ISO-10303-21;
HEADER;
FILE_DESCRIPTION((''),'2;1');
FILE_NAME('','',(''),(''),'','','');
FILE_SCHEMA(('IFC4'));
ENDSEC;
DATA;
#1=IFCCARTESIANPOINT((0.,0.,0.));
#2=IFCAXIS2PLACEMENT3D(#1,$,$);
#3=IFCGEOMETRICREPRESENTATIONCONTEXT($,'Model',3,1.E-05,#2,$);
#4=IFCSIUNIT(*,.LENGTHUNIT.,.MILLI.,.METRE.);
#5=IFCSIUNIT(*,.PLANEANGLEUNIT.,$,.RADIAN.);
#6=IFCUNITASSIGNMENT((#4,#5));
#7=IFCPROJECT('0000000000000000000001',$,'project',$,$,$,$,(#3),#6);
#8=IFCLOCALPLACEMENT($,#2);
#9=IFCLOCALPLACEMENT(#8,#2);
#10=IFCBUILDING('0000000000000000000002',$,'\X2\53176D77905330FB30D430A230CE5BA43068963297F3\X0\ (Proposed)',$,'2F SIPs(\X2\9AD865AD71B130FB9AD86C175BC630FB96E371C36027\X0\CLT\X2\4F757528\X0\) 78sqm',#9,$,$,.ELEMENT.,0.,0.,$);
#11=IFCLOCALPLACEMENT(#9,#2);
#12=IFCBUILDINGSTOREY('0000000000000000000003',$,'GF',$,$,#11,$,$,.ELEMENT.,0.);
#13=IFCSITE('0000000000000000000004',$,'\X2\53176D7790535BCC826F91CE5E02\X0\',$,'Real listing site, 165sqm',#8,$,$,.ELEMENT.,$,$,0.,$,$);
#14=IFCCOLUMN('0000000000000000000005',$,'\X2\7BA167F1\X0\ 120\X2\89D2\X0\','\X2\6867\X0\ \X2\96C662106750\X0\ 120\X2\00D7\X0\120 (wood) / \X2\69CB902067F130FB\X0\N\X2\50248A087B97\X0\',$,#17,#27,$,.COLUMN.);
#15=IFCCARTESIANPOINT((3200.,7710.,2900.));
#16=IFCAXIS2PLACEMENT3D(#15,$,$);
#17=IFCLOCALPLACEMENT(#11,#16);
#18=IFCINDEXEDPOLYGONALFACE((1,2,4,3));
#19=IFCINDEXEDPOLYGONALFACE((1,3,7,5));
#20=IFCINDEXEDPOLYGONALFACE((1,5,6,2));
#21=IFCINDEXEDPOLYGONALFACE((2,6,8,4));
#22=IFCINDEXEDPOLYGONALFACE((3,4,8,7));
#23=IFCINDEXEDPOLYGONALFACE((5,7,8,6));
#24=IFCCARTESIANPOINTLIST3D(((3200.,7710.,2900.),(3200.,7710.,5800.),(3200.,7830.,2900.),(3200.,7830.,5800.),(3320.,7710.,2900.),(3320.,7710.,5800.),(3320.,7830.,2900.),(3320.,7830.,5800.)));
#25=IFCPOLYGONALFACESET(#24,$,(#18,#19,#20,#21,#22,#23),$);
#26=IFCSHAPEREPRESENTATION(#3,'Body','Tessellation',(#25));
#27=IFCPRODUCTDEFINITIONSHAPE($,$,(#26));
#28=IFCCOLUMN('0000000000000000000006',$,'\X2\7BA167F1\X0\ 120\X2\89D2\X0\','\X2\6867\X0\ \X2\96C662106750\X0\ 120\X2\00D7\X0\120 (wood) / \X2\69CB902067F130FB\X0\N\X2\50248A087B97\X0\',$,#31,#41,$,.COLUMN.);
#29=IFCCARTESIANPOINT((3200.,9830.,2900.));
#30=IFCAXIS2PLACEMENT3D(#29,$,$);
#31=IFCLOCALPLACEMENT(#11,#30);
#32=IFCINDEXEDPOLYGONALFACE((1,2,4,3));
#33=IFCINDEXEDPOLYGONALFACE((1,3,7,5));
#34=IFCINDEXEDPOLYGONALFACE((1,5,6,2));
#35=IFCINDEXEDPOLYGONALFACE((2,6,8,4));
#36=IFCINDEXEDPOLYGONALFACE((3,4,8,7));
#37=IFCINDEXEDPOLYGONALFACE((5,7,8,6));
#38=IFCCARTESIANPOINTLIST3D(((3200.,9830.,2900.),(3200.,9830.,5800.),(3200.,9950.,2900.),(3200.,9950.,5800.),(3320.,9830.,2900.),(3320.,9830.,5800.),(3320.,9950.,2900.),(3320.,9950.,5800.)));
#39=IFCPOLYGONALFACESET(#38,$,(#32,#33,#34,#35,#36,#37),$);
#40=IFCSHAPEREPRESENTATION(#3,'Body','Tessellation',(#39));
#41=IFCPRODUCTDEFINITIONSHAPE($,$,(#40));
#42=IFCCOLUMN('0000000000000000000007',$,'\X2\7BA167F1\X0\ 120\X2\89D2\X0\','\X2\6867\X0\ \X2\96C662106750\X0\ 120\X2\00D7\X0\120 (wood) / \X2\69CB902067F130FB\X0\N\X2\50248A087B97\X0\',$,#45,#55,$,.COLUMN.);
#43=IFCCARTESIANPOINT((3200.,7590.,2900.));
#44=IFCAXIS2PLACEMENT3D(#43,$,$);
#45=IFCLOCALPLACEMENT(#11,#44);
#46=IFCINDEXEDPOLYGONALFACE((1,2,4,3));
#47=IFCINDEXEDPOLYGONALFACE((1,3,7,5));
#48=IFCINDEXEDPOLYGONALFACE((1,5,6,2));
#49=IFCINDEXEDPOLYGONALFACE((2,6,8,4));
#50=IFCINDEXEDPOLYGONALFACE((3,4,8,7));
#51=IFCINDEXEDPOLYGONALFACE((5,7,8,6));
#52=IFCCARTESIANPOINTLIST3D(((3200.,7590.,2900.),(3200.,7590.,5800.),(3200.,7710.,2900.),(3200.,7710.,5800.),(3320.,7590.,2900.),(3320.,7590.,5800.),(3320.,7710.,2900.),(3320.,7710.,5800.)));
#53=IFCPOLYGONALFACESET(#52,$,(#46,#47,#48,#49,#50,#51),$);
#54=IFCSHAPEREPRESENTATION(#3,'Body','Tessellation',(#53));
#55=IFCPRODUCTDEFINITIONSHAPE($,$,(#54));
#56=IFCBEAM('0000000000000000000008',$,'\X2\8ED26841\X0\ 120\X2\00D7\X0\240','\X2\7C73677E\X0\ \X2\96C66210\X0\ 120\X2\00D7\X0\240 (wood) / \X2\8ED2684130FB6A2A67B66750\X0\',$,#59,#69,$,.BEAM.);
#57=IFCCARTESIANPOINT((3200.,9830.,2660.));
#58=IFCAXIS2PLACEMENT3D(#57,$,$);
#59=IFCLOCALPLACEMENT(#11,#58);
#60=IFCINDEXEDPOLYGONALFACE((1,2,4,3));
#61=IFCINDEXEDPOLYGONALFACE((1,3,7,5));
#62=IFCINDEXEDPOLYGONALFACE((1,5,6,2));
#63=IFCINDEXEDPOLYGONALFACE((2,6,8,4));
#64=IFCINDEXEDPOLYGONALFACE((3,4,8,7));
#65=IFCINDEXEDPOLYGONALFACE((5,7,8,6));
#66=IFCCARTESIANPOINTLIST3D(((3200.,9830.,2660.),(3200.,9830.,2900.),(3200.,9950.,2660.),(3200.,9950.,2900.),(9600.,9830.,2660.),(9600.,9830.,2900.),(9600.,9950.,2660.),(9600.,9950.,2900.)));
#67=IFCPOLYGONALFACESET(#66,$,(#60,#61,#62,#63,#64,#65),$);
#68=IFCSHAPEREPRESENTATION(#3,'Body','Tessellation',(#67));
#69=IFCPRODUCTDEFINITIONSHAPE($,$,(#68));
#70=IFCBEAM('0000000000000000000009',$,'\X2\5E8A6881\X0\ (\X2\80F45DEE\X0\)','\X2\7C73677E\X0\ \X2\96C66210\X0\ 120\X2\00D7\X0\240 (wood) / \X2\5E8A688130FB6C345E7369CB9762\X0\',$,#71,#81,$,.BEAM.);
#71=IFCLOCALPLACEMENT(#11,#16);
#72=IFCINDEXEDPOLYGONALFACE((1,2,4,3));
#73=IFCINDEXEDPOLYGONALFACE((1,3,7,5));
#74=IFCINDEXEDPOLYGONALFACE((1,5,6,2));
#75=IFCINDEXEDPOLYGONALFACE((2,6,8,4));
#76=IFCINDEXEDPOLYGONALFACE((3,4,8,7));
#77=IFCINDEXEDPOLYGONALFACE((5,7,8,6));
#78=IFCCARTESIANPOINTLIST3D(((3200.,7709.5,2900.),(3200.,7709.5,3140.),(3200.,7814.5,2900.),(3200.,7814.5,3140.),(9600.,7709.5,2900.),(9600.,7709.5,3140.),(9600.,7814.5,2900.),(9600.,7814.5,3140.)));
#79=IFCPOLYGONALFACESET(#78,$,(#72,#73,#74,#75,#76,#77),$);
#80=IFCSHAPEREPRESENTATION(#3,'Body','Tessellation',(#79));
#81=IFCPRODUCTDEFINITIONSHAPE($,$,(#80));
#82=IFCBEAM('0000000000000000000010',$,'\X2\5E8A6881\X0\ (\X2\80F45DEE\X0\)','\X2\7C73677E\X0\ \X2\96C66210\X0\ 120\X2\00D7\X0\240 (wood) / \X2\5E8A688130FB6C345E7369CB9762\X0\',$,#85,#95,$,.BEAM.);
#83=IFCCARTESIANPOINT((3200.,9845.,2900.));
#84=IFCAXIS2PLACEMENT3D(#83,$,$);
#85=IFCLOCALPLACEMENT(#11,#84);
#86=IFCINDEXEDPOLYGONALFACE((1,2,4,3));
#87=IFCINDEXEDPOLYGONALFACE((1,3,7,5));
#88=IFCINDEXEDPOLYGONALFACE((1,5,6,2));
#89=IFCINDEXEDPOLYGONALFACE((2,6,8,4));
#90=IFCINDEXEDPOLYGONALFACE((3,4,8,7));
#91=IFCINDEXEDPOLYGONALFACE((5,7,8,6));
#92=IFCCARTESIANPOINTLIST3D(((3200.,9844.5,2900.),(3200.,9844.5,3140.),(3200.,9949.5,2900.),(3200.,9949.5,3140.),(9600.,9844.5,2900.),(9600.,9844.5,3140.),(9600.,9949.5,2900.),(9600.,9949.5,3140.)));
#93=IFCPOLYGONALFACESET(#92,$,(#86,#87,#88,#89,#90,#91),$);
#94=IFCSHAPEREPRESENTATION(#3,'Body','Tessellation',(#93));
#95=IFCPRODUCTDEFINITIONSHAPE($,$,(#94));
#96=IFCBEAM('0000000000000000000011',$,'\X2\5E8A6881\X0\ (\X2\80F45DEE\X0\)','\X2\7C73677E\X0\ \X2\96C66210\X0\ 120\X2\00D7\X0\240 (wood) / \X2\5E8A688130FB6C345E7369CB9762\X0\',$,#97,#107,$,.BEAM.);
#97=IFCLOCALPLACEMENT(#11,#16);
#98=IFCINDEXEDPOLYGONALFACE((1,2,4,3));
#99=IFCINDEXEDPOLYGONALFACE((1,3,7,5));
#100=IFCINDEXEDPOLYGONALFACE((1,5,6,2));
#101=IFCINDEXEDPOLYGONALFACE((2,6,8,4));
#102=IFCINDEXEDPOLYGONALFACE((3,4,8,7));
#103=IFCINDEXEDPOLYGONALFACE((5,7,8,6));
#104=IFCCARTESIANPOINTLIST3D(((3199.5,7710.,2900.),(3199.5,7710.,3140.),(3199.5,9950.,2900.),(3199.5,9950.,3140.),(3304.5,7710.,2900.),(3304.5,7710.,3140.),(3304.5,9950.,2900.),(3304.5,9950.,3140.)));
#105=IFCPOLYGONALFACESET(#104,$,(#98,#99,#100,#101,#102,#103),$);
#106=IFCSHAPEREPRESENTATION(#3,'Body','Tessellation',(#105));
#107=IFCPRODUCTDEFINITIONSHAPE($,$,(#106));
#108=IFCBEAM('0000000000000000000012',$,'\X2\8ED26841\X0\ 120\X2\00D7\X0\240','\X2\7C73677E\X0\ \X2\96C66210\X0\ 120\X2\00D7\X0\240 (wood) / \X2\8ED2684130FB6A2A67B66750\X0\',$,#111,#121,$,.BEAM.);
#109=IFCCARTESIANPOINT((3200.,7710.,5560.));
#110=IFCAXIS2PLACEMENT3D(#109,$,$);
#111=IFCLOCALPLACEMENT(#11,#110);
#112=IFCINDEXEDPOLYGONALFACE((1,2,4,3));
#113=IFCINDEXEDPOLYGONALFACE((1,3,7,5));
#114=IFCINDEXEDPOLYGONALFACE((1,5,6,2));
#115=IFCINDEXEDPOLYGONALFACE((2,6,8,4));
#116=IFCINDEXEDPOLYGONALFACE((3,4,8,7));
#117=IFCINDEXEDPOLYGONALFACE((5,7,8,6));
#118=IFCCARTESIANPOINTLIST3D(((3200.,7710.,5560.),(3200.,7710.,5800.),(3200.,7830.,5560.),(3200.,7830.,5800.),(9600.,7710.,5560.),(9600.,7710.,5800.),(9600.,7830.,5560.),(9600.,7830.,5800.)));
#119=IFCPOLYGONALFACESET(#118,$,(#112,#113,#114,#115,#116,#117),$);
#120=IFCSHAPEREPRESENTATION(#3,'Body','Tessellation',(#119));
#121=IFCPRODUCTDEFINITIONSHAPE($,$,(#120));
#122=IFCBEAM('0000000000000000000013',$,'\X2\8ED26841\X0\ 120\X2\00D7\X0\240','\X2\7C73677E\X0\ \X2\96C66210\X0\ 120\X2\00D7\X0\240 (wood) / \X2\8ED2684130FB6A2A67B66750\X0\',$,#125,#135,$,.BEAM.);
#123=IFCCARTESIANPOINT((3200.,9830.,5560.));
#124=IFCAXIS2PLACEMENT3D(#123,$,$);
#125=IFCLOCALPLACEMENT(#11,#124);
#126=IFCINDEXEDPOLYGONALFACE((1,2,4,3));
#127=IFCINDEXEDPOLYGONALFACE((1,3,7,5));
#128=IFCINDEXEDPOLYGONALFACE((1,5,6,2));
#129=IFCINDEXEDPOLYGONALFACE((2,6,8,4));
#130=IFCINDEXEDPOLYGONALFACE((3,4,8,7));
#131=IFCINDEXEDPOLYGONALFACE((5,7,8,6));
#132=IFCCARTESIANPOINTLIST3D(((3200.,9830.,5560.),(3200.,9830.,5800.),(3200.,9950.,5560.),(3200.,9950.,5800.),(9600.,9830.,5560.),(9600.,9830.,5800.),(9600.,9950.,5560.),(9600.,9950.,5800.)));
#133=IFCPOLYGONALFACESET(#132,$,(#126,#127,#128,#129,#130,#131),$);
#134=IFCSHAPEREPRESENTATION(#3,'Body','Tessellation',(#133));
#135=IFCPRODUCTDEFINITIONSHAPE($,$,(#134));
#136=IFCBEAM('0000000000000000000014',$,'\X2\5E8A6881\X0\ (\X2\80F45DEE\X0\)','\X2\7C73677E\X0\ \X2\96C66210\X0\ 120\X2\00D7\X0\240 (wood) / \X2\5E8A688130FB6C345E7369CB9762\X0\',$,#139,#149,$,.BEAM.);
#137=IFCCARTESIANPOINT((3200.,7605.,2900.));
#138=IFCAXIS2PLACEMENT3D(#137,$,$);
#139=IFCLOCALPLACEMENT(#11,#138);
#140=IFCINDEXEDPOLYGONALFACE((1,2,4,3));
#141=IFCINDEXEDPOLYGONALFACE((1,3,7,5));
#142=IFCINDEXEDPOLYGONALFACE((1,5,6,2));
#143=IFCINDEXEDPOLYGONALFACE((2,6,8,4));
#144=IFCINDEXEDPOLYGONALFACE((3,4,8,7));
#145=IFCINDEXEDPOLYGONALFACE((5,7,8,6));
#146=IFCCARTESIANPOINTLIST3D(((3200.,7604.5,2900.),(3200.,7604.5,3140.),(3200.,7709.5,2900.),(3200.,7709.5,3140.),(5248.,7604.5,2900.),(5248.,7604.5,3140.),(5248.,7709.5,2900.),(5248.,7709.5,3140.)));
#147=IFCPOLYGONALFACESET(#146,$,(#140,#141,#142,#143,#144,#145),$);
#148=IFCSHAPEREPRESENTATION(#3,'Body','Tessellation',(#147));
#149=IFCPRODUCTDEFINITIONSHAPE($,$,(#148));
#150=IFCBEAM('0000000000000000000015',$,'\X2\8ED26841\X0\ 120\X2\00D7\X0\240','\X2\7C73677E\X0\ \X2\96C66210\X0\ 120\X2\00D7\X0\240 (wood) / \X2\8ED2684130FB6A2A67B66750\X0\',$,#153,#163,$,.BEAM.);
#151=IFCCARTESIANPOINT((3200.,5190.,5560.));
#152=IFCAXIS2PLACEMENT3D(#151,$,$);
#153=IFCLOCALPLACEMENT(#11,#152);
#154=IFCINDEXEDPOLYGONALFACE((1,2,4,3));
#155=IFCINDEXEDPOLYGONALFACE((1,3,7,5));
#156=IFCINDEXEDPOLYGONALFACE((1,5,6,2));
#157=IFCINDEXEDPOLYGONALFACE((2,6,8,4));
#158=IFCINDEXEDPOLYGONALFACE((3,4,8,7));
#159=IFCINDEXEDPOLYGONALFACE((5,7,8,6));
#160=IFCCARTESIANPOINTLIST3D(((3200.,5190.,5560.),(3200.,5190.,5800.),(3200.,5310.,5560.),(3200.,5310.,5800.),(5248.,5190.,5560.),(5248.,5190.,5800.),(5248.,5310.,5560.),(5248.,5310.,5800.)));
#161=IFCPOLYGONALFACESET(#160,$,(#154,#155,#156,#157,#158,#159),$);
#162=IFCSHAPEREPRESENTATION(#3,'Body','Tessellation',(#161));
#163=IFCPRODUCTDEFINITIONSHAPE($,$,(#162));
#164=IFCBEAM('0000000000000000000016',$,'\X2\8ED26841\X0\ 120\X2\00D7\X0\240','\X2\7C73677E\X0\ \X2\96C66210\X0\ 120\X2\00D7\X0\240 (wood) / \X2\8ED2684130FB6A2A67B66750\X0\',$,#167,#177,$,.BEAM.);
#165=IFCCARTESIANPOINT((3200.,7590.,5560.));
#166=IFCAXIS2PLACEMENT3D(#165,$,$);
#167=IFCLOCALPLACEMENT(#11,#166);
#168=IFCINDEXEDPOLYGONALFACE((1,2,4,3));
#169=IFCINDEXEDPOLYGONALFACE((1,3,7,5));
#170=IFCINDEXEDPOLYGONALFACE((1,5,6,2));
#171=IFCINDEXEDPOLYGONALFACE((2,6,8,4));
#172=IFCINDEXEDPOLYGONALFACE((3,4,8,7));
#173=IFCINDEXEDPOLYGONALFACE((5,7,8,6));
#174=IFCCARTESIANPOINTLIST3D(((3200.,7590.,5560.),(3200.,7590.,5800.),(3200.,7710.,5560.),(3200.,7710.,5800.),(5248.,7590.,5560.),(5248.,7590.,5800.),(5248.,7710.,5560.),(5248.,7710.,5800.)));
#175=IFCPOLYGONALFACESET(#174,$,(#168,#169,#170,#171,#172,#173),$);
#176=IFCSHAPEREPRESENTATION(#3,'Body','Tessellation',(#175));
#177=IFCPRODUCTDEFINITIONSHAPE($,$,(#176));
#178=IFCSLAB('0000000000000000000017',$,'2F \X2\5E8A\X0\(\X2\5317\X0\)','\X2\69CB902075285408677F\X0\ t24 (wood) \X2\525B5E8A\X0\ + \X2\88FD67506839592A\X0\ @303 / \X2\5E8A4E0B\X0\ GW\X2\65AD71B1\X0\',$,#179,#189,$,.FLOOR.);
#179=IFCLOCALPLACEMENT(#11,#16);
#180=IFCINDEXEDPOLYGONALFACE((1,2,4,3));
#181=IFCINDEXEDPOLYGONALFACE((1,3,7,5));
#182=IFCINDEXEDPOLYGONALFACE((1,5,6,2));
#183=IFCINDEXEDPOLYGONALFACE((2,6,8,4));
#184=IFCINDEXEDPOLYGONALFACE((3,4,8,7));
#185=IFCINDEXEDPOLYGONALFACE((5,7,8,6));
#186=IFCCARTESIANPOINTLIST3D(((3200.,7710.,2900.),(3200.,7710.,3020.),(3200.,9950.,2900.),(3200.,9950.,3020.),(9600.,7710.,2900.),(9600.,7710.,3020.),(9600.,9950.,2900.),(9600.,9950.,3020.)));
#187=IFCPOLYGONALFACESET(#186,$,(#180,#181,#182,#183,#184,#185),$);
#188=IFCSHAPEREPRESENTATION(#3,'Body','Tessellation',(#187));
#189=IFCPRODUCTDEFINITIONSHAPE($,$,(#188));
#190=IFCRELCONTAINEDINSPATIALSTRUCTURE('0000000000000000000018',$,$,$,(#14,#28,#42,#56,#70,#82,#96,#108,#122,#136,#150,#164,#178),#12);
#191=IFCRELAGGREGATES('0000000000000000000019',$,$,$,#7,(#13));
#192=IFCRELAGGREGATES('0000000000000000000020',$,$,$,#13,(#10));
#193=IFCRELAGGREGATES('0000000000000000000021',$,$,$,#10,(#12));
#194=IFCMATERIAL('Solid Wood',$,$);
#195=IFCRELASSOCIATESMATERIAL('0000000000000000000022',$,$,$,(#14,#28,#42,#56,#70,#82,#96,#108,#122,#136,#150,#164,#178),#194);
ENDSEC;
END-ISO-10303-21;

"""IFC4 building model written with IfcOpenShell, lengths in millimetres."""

from ifc_helpers import new_model, si_unit, frame, frame_2d, origin, place, context, project, spatial, rectangle, extrude, material, element, save


model = new_model("IFC4")

# Units and contexts
model_context = context("Model", 3, precision=1e-05, world=origin())
ifc_project = project(units=[si_unit("LENGTHUNIT", "METRE", prefix="MILLI"), si_unit("PLANEANGLEUNIT", "RADIAN")], contexts=[model_context])

# Site, building, storey
site_placement = place(None, origin())
site = spatial("IfcSite", under=ifc_project, at=site_placement, Name="北海道富良野市", ObjectType="Real listing site, 165sqm", CompositionType="ELEMENT", RefElevation=0.0)
building_placement = place(site_placement, origin())
building = spatial("IfcBuilding", under=site, at=building_placement, Name="北海道・ピアノ室と防音 (Proposed)", ObjectType="2F SIPs(高断熱・高気密・難燃性CLT併用) 78sqm", CompositionType="ELEMENT", ElevationOfRefHeight=0.0, ElevationOfTerrain=0.0)
storey_placement = place(building_placement, origin())
storey = spatial("IfcBuildingStorey", under=building, at=storey_placement, Name="GF", CompositionType="ELEMENT", Elevation=0.0)

# Columns
ifc_material_1 = material(Name="Solid Wood")
column_1_placement = place(storey_placement, frame((3200.0, 7710.0, 2900.0)))
element("IfcColumn", 1, at=column_1_placement, inside=storey, material=ifc_material_1, Name="管柱 120角", Description="桧 集成材 120×120 (wood) / 構造柱・N値計算", PredefinedType="COLUMN", context=model_context, shape_type="SweptSolid", body=[
    extrude(rectangle(XDim=120.0, YDim=120.0, at=frame_2d((60.0, 60.0))), frame((3200.0, 7710.0, 2900.0)), (0.0, 0.0, 1.0), 2900.0),
])
column_2_placement = place(storey_placement, frame((3200.0, 9830.0, 2900.0)))
element("IfcColumn", 2, at=column_2_placement, inside=storey, material=ifc_material_1, Name="管柱 120角", Description="桧 集成材 120×120 (wood) / 構造柱・N値計算", PredefinedType="COLUMN", context=model_context, shape_type="SweptSolid", body=[
    extrude(rectangle(XDim=120.0, YDim=120.0, at=frame_2d((60.0, 60.0))), frame((3200.0, 9830.0, 2900.0)), (0.0, 0.0, 1.0), 2900.0),
])
column_3_placement = place(storey_placement, frame((3200.0, 7590.0, 2900.0)))
element("IfcColumn", 3, at=column_3_placement, inside=storey, material=ifc_material_1, Name="管柱 120角", Description="桧 集成材 120×120 (wood) / 構造柱・N値計算", PredefinedType="COLUMN", context=model_context, shape_type="SweptSolid", body=[
    extrude(rectangle(XDim=120.0, YDim=120.0, at=frame_2d((60.0, 60.0))), frame((3200.0, 7590.0, 2900.0)), (0.0, 0.0, 1.0), 2900.0),
])

# Beams
beam_1_placement = place(storey_placement, frame((3200.0, 9830.0, 2660.0)))
element("IfcBeam", 4, at=beam_1_placement, inside=storey, material=ifc_material_1, Name="軒桁 120×240", Description="米松 集成 120×240 (wood) / 軒桁・横架材", PredefinedType="BEAM", context=model_context, shape_type="SweptSolid", body=[
    extrude(rectangle(XDim=6400.0, YDim=120.0, at=frame_2d((3200.0, 60.0))), frame((3200.0, 9830.0, 2660.0)), (0.0, 0.0, 1.0), 240.0),
])
beam_2_placement = place(storey_placement, frame((3200.0, 7710.0, 2900.0)))
element("IfcBeam", 5, at=beam_2_placement, inside=storey, material=ifc_material_1, Name="床梁 (胴差)", Description="米松 集成 120×240 (wood) / 床梁・水平構面", PredefinedType="BEAM", context=model_context, shape_type="SweptSolid", body=[
    extrude(rectangle(XDim=6400.0, YDim=105.0, at=frame_2d((3200.0, 52.0))), frame((3200.0, 7710.0, 2900.0)), (0.0, 0.0, 1.0), 240.0),
])
beam_3_placement = place(storey_placement, frame((3200.0, 9845.0, 2900.0)))
element("IfcBeam", 6, at=beam_3_placement, inside=storey, material=ifc_material_1, Name="床梁 (胴差)", Description="米松 集成 120×240 (wood) / 床梁・水平構面", PredefinedType="BEAM", context=model_context, shape_type="SweptSolid", body=[
    extrude(rectangle(XDim=6400.0, YDim=105.0, at=frame_2d((3200.0, 52.0))), frame((3200.0, 9845.0, 2900.0)), (0.0, 0.0, 1.0), 240.0),
])
beam_4_placement = place(storey_placement, frame((3200.0, 7710.0, 2900.0)))
element("IfcBeam", 7, at=beam_4_placement, inside=storey, material=ifc_material_1, Name="床梁 (胴差)", Description="米松 集成 120×240 (wood) / 床梁・水平構面", PredefinedType="BEAM", context=model_context, shape_type="SweptSolid", body=[
    extrude(rectangle(XDim=105.0, YDim=2240.0, at=frame_2d((52.0, 1120.0))), frame((3200.0, 7710.0, 2900.0)), (0.0, 0.0, 1.0), 240.0),
])
beam_5_placement = place(storey_placement, frame((3200.0, 7710.0, 5560.0)))
element("IfcBeam", 8, at=beam_5_placement, inside=storey, material=ifc_material_1, Name="軒桁 120×240", Description="米松 集成 120×240 (wood) / 軒桁・横架材", PredefinedType="BEAM", context=model_context, shape_type="SweptSolid", body=[
    extrude(rectangle(XDim=6400.0, YDim=120.0, at=frame_2d((3200.0, 60.0))), frame((3200.0, 7710.0, 5560.0)), (0.0, 0.0, 1.0), 240.0),
])
beam_6_placement = place(storey_placement, frame((3200.0, 9830.0, 5560.0)))
element("IfcBeam", 9, at=beam_6_placement, inside=storey, material=ifc_material_1, Name="軒桁 120×240", Description="米松 集成 120×240 (wood) / 軒桁・横架材", PredefinedType="BEAM", context=model_context, shape_type="SweptSolid", body=[
    extrude(rectangle(XDim=6400.0, YDim=120.0, at=frame_2d((3200.0, 60.0))), frame((3200.0, 9830.0, 5560.0)), (0.0, 0.0, 1.0), 240.0),
])
beam_7_placement = place(storey_placement, frame((3200.0, 7605.0, 2900.0)))
element("IfcBeam", 10, at=beam_7_placement, inside=storey, material=ifc_material_1, Name="床梁 (胴差)", Description="米松 集成 120×240 (wood) / 床梁・水平構面", PredefinedType="BEAM", context=model_context, shape_type="SweptSolid", body=[
    extrude(rectangle(XDim=2048.0, YDim=105.0, at=frame_2d((1024.0, 52.0))), frame((3200.0, 7605.0, 2900.0)), (0.0, 0.0, 1.0), 240.0),
])
beam_8_placement = place(storey_placement, frame((3200.0, 5190.0, 5560.0)))
element("IfcBeam", 11, at=beam_8_placement, inside=storey, material=ifc_material_1, Name="軒桁 120×240", Description="米松 集成 120×240 (wood) / 軒桁・横架材", PredefinedType="BEAM", context=model_context, shape_type="SweptSolid", body=[
    extrude(rectangle(XDim=2048.0, YDim=120.0, at=frame_2d((1024.0, 60.0))), frame((3200.0, 5190.0, 5560.0)), (0.0, 0.0, 1.0), 240.0),
])
beam_9_placement = place(storey_placement, frame((3200.0, 7590.0, 5560.0)))
element("IfcBeam", 12, at=beam_9_placement, inside=storey, material=ifc_material_1, Name="軒桁 120×240", Description="米松 集成 120×240 (wood) / 軒桁・横架材", PredefinedType="BEAM", context=model_context, shape_type="SweptSolid", body=[
    extrude(rectangle(XDim=2048.0, YDim=120.0, at=frame_2d((1024.0, 60.0))), frame((3200.0, 7590.0, 5560.0)), (0.0, 0.0, 1.0), 240.0),
])

# Slab
slab_placement = place(storey_placement, frame((3200.0, 7710.0, 2900.0)))
element("IfcSlab", 13, at=slab_placement, inside=storey, material=ifc_material_1, Name="2F 床(北)", Description="構造用合板 t24 (wood) 剛床 + 製材根太 @303 / 床下 GW断熱", PredefinedType="FLOOR", context=model_context, shape_type="SweptSolid", body=[
    extrude(rectangle(XDim=6400.0, YDim=2240.0, at=frame_2d((3200.0, 1120.0))), frame((3200.0, 7710.0, 2900.0)), (0.0, 0.0, 1.0), 120.0),
])

save(model, "model.ifc")
